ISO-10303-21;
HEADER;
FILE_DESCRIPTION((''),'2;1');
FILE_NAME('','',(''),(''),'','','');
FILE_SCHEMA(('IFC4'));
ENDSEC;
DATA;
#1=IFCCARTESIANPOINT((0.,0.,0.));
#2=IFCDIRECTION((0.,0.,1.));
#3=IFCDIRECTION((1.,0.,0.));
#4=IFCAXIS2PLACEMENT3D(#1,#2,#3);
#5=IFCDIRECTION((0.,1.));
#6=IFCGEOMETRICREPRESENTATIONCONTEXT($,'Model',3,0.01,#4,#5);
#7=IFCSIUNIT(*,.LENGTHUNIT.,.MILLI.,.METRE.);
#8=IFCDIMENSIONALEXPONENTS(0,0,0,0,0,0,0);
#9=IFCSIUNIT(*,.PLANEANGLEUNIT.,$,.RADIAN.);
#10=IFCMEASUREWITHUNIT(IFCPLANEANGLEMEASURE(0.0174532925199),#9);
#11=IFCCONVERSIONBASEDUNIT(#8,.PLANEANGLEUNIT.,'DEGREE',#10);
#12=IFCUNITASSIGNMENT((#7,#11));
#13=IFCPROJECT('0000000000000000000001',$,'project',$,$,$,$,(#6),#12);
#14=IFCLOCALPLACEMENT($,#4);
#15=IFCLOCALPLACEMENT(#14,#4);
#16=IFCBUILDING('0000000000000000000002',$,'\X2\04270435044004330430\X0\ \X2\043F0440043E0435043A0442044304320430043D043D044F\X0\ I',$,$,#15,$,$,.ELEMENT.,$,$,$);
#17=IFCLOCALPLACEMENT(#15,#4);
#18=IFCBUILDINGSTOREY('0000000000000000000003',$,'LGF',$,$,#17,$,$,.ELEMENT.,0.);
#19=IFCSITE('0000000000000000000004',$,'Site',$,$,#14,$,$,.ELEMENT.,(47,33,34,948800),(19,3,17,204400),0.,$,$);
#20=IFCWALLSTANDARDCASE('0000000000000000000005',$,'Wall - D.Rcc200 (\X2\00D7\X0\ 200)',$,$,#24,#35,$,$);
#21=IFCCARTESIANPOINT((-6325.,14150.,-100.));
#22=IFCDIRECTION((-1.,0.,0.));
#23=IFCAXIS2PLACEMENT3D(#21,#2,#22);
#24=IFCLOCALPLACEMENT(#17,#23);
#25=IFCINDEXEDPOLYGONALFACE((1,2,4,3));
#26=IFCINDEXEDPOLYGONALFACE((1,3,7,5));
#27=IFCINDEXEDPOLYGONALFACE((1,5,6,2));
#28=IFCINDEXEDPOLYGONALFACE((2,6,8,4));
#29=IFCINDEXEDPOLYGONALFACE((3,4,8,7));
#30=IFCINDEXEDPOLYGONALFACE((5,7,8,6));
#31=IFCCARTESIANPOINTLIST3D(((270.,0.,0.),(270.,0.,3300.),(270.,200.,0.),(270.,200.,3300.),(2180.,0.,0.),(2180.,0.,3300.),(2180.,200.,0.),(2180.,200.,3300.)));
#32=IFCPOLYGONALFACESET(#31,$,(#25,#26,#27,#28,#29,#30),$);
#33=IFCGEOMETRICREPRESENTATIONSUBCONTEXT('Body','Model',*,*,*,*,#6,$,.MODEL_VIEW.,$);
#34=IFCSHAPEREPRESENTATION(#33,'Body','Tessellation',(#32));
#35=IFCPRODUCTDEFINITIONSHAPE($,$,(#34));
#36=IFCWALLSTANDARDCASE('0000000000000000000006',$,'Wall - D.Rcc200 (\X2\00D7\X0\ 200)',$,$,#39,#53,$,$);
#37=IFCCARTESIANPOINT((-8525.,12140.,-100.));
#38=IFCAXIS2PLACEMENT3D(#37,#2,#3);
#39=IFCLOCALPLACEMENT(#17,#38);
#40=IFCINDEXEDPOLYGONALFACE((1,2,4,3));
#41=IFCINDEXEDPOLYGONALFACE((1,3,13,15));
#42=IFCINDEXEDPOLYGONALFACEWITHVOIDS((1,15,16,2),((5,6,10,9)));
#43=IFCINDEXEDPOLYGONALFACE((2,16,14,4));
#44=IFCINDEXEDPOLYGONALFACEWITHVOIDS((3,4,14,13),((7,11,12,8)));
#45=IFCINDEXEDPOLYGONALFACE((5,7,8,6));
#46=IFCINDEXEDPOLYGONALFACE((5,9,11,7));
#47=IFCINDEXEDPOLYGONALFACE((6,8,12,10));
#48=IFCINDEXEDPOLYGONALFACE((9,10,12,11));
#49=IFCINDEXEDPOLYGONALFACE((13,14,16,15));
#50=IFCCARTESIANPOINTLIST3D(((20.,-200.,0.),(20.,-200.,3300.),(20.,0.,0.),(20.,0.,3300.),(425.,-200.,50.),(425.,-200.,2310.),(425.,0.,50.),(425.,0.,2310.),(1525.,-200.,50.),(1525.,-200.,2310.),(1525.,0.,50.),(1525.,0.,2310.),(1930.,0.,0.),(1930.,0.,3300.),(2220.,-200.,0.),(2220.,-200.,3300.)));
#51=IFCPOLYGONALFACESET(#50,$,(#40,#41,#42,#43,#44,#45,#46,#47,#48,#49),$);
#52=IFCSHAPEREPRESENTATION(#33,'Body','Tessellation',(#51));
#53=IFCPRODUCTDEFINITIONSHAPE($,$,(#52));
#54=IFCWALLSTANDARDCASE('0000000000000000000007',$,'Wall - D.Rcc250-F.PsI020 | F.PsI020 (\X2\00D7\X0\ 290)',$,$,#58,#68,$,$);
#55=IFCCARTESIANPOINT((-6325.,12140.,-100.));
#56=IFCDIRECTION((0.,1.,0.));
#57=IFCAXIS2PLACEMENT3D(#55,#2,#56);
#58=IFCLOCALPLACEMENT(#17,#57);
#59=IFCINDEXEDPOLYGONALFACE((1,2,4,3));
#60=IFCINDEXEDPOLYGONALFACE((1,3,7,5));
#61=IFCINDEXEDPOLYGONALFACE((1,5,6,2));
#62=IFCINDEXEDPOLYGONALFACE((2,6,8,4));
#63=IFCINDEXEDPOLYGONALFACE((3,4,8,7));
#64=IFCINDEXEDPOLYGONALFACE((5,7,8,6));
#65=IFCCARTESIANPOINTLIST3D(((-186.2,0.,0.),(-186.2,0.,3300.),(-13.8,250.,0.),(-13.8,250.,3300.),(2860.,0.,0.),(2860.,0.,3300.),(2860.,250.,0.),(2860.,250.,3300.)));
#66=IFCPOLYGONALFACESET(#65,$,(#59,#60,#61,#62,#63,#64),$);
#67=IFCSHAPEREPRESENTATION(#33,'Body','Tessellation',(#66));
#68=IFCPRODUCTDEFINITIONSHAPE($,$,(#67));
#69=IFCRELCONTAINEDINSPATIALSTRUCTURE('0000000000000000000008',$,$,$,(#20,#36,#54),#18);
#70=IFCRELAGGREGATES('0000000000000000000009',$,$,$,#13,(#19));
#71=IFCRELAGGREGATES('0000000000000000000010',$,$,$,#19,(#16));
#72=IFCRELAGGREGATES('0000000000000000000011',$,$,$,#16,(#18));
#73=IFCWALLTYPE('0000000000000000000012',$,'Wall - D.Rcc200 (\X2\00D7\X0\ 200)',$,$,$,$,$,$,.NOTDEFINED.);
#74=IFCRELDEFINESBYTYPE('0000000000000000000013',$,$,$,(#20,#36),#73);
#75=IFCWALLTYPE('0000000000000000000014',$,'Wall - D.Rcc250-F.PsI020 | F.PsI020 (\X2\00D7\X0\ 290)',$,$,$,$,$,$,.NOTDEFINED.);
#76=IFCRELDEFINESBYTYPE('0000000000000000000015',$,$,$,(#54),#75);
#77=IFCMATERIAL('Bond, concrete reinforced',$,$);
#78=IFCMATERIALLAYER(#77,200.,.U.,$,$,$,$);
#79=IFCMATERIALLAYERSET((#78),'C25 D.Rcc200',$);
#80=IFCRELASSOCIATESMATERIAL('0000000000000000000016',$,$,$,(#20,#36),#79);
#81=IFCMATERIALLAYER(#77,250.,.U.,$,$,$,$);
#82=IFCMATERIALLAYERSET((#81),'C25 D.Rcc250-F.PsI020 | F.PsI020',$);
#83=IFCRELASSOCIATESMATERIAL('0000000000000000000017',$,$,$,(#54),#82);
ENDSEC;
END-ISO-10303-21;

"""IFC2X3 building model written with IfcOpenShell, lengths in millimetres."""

from ifc_helpers import new_model, entity, si_unit, converted_unit, direction, frame, origin_with_axes, origin_2d_with_axis, place, context, subcontext, project, spatial, polyline, rectangle, outline, extrude, material, layer, layer_set, layer_usage, type_object, element, save


model = new_model("IFC2X3")

# Units and contexts
model_context = context("Model", 3, precision=0.01, world=origin_with_axes(), true_north=direction((0.0, 1.0)))
body_context = subcontext(model_context, "Body", "Model", "MODEL_VIEW")
ifc_project = project(units=[si_unit("LENGTHUNIT", "METRE", prefix="MILLI"), converted_unit("PLANEANGLEUNIT", "DEGREE", entity("IfcPlaneAngleMeasure", 0.0174532925199), si_unit("PLANEANGLEUNIT", "RADIAN"), dimensions=[0, 0, 0, 0, 0, 0, 0])], contexts=[model_context])

# Site, building, storey
site_placement = place(None, origin_with_axes())
site = spatial("IfcSite", under=ifc_project, at=site_placement, Name="Site", CompositionType="ELEMENT", RefLatitude=(47, 33, 34, 948800), RefLongitude=(19, 3, 17, 204400), RefElevation=0.0)
building_placement = place(site_placement, origin_with_axes())
building = spatial("IfcBuilding", under=site, at=building_placement, Name="Черга проектування I", CompositionType="ELEMENT")
storey_placement = place(building_placement, origin_with_axes())
storey = spatial("IfcBuildingStorey", under=building, at=storey_placement, Name="LGF", CompositionType="ELEMENT", Elevation=0.0)

# Shared definitions
ifc_material = material(Name="Bond, concrete reinforced")

# Wall
ifc_layer_1 = layer(ifc_material, 200.0, ventilated="UNKNOWN")
ifc_layer_set_1 = layer_set([ifc_layer_1], Name="C25 D.Rcc200")
ifc_layer_usage_1 = layer_usage(ifc_layer_set_1, "AXIS2", "POSITIVE", 0.0)
wall_type_1 = type_object("IfcWallType", Name="Wall - D.Rcc200 (× 200)", PredefinedType="NOTDEFINED")
wall_1_placement = place(storey_placement, frame((-6325.0, 14150.0, -100.0), z_axis=(0.0, 0.0, 1.0), x_axis=(-1.0, 0.0, 0.0)))
element("IfcWallStandardCase", 1, at=wall_1_placement, inside=storey, type_object=wall_type_1, material=ifc_layer_usage_1, Name="Wall - D.Rcc200 (× 200)", context=body_context, shape_type="SweptSolid", body=[
    extrude(outline(polyline([(270.0, 0.0), (2180.0, 0.0), (2180.0, 200.0), (270.0, 200.0), (270.0, 0.0)])), origin_with_axes(), (0.0, 0.0, 1.0), 3300.0),
])

# Wall, opening
ifc_layer_usage_2 = layer_usage(ifc_layer_set_1, "AXIS2", "POSITIVE", -200.0)
wall_2_placement = place(storey_placement, frame((-8525.0, 12140.0, -100.0), z_axis=(0.0, 0.0, 1.0), x_axis=(1.0, 0.0, 0.0)))
wall_2 = element("IfcWallStandardCase", 2, at=wall_2_placement, inside=storey, type_object=wall_type_1, material=ifc_layer_usage_2, Name="Wall - D.Rcc200 (× 200)", context=body_context, shape_type="SweptSolid", body=[
    extrude(outline(polyline([(20.0, -200.0), (2220.0, -200.0), (1930.0, 0.0), (20.0, 0.0), (20.0, -200.0)])), origin_with_axes(), (0.0, 0.0, 1.0), 3300.0),
])
opening_placement = place(wall_2_placement, frame((975.0, 0.0, 50.0), z_axis=(0.0, 0.0, 1.0), x_axis=(1.0, 0.0, 0.0)))
element("IfcOpeningElement", 3, at=opening_placement, cuts=wall_2, context=body_context, shape_type="SweptSolid", body=[
    extrude(rectangle(XDim=1100.0, YDim=2260.0, at=origin_2d_with_axis()), frame((0.0, 0.0, 1130.0), z_axis=(0.0, -1.0, 0.0), x_axis=(1.0, 0.0, 0.0)), (0.0, 0.0, -1.0), 200.0),
    extrude(rectangle(XDim=1100.0, YDim=2260.0, at=origin_2d_with_axis()), frame((0.0, 0.0, 1130.0), z_axis=(0.0, 1.0, 0.0), x_axis=(1.0, 0.0, 0.0)), (0.0, 0.0, -1.0), 200.0),
])

# Wall
ifc_layer_2 = layer(ifc_material, 250.0, ventilated="UNKNOWN")
ifc_layer_set_2 = layer_set([ifc_layer_2], Name="C25 D.Rcc250-F.PsI020 | F.PsI020")
wall_type_2 = type_object("IfcWallType", Name="Wall - D.Rcc250-F.PsI020 | F.PsI020 (× 290)", PredefinedType="NOTDEFINED")
ifc_layer_usage_3 = layer_usage(ifc_layer_set_2, "AXIS2", "NEGATIVE", 250.0)
wall_3_placement = place(storey_placement, frame((-6325.0, 12140.0, -100.0), z_axis=(0.0, 0.0, 1.0), x_axis=(0.0, 1.0, 0.0)))
element("IfcWallStandardCase", 4, at=wall_3_placement, inside=storey, type_object=wall_type_2, material=ifc_layer_usage_3, Name="Wall - D.Rcc250-F.PsI020 | F.PsI020 (× 290)", context=body_context, shape_type="SweptSolid", body=[
    extrude(outline(polyline([(-186.2, 0.0), (2860.0, 0.0), (2860.0, 250.0), (-13.8, 250.0), (-186.2, 0.0)])), origin_with_axes(), (0.0, 0.0, 1.0), 3300.0),
])

save(model, "model.ifc")
